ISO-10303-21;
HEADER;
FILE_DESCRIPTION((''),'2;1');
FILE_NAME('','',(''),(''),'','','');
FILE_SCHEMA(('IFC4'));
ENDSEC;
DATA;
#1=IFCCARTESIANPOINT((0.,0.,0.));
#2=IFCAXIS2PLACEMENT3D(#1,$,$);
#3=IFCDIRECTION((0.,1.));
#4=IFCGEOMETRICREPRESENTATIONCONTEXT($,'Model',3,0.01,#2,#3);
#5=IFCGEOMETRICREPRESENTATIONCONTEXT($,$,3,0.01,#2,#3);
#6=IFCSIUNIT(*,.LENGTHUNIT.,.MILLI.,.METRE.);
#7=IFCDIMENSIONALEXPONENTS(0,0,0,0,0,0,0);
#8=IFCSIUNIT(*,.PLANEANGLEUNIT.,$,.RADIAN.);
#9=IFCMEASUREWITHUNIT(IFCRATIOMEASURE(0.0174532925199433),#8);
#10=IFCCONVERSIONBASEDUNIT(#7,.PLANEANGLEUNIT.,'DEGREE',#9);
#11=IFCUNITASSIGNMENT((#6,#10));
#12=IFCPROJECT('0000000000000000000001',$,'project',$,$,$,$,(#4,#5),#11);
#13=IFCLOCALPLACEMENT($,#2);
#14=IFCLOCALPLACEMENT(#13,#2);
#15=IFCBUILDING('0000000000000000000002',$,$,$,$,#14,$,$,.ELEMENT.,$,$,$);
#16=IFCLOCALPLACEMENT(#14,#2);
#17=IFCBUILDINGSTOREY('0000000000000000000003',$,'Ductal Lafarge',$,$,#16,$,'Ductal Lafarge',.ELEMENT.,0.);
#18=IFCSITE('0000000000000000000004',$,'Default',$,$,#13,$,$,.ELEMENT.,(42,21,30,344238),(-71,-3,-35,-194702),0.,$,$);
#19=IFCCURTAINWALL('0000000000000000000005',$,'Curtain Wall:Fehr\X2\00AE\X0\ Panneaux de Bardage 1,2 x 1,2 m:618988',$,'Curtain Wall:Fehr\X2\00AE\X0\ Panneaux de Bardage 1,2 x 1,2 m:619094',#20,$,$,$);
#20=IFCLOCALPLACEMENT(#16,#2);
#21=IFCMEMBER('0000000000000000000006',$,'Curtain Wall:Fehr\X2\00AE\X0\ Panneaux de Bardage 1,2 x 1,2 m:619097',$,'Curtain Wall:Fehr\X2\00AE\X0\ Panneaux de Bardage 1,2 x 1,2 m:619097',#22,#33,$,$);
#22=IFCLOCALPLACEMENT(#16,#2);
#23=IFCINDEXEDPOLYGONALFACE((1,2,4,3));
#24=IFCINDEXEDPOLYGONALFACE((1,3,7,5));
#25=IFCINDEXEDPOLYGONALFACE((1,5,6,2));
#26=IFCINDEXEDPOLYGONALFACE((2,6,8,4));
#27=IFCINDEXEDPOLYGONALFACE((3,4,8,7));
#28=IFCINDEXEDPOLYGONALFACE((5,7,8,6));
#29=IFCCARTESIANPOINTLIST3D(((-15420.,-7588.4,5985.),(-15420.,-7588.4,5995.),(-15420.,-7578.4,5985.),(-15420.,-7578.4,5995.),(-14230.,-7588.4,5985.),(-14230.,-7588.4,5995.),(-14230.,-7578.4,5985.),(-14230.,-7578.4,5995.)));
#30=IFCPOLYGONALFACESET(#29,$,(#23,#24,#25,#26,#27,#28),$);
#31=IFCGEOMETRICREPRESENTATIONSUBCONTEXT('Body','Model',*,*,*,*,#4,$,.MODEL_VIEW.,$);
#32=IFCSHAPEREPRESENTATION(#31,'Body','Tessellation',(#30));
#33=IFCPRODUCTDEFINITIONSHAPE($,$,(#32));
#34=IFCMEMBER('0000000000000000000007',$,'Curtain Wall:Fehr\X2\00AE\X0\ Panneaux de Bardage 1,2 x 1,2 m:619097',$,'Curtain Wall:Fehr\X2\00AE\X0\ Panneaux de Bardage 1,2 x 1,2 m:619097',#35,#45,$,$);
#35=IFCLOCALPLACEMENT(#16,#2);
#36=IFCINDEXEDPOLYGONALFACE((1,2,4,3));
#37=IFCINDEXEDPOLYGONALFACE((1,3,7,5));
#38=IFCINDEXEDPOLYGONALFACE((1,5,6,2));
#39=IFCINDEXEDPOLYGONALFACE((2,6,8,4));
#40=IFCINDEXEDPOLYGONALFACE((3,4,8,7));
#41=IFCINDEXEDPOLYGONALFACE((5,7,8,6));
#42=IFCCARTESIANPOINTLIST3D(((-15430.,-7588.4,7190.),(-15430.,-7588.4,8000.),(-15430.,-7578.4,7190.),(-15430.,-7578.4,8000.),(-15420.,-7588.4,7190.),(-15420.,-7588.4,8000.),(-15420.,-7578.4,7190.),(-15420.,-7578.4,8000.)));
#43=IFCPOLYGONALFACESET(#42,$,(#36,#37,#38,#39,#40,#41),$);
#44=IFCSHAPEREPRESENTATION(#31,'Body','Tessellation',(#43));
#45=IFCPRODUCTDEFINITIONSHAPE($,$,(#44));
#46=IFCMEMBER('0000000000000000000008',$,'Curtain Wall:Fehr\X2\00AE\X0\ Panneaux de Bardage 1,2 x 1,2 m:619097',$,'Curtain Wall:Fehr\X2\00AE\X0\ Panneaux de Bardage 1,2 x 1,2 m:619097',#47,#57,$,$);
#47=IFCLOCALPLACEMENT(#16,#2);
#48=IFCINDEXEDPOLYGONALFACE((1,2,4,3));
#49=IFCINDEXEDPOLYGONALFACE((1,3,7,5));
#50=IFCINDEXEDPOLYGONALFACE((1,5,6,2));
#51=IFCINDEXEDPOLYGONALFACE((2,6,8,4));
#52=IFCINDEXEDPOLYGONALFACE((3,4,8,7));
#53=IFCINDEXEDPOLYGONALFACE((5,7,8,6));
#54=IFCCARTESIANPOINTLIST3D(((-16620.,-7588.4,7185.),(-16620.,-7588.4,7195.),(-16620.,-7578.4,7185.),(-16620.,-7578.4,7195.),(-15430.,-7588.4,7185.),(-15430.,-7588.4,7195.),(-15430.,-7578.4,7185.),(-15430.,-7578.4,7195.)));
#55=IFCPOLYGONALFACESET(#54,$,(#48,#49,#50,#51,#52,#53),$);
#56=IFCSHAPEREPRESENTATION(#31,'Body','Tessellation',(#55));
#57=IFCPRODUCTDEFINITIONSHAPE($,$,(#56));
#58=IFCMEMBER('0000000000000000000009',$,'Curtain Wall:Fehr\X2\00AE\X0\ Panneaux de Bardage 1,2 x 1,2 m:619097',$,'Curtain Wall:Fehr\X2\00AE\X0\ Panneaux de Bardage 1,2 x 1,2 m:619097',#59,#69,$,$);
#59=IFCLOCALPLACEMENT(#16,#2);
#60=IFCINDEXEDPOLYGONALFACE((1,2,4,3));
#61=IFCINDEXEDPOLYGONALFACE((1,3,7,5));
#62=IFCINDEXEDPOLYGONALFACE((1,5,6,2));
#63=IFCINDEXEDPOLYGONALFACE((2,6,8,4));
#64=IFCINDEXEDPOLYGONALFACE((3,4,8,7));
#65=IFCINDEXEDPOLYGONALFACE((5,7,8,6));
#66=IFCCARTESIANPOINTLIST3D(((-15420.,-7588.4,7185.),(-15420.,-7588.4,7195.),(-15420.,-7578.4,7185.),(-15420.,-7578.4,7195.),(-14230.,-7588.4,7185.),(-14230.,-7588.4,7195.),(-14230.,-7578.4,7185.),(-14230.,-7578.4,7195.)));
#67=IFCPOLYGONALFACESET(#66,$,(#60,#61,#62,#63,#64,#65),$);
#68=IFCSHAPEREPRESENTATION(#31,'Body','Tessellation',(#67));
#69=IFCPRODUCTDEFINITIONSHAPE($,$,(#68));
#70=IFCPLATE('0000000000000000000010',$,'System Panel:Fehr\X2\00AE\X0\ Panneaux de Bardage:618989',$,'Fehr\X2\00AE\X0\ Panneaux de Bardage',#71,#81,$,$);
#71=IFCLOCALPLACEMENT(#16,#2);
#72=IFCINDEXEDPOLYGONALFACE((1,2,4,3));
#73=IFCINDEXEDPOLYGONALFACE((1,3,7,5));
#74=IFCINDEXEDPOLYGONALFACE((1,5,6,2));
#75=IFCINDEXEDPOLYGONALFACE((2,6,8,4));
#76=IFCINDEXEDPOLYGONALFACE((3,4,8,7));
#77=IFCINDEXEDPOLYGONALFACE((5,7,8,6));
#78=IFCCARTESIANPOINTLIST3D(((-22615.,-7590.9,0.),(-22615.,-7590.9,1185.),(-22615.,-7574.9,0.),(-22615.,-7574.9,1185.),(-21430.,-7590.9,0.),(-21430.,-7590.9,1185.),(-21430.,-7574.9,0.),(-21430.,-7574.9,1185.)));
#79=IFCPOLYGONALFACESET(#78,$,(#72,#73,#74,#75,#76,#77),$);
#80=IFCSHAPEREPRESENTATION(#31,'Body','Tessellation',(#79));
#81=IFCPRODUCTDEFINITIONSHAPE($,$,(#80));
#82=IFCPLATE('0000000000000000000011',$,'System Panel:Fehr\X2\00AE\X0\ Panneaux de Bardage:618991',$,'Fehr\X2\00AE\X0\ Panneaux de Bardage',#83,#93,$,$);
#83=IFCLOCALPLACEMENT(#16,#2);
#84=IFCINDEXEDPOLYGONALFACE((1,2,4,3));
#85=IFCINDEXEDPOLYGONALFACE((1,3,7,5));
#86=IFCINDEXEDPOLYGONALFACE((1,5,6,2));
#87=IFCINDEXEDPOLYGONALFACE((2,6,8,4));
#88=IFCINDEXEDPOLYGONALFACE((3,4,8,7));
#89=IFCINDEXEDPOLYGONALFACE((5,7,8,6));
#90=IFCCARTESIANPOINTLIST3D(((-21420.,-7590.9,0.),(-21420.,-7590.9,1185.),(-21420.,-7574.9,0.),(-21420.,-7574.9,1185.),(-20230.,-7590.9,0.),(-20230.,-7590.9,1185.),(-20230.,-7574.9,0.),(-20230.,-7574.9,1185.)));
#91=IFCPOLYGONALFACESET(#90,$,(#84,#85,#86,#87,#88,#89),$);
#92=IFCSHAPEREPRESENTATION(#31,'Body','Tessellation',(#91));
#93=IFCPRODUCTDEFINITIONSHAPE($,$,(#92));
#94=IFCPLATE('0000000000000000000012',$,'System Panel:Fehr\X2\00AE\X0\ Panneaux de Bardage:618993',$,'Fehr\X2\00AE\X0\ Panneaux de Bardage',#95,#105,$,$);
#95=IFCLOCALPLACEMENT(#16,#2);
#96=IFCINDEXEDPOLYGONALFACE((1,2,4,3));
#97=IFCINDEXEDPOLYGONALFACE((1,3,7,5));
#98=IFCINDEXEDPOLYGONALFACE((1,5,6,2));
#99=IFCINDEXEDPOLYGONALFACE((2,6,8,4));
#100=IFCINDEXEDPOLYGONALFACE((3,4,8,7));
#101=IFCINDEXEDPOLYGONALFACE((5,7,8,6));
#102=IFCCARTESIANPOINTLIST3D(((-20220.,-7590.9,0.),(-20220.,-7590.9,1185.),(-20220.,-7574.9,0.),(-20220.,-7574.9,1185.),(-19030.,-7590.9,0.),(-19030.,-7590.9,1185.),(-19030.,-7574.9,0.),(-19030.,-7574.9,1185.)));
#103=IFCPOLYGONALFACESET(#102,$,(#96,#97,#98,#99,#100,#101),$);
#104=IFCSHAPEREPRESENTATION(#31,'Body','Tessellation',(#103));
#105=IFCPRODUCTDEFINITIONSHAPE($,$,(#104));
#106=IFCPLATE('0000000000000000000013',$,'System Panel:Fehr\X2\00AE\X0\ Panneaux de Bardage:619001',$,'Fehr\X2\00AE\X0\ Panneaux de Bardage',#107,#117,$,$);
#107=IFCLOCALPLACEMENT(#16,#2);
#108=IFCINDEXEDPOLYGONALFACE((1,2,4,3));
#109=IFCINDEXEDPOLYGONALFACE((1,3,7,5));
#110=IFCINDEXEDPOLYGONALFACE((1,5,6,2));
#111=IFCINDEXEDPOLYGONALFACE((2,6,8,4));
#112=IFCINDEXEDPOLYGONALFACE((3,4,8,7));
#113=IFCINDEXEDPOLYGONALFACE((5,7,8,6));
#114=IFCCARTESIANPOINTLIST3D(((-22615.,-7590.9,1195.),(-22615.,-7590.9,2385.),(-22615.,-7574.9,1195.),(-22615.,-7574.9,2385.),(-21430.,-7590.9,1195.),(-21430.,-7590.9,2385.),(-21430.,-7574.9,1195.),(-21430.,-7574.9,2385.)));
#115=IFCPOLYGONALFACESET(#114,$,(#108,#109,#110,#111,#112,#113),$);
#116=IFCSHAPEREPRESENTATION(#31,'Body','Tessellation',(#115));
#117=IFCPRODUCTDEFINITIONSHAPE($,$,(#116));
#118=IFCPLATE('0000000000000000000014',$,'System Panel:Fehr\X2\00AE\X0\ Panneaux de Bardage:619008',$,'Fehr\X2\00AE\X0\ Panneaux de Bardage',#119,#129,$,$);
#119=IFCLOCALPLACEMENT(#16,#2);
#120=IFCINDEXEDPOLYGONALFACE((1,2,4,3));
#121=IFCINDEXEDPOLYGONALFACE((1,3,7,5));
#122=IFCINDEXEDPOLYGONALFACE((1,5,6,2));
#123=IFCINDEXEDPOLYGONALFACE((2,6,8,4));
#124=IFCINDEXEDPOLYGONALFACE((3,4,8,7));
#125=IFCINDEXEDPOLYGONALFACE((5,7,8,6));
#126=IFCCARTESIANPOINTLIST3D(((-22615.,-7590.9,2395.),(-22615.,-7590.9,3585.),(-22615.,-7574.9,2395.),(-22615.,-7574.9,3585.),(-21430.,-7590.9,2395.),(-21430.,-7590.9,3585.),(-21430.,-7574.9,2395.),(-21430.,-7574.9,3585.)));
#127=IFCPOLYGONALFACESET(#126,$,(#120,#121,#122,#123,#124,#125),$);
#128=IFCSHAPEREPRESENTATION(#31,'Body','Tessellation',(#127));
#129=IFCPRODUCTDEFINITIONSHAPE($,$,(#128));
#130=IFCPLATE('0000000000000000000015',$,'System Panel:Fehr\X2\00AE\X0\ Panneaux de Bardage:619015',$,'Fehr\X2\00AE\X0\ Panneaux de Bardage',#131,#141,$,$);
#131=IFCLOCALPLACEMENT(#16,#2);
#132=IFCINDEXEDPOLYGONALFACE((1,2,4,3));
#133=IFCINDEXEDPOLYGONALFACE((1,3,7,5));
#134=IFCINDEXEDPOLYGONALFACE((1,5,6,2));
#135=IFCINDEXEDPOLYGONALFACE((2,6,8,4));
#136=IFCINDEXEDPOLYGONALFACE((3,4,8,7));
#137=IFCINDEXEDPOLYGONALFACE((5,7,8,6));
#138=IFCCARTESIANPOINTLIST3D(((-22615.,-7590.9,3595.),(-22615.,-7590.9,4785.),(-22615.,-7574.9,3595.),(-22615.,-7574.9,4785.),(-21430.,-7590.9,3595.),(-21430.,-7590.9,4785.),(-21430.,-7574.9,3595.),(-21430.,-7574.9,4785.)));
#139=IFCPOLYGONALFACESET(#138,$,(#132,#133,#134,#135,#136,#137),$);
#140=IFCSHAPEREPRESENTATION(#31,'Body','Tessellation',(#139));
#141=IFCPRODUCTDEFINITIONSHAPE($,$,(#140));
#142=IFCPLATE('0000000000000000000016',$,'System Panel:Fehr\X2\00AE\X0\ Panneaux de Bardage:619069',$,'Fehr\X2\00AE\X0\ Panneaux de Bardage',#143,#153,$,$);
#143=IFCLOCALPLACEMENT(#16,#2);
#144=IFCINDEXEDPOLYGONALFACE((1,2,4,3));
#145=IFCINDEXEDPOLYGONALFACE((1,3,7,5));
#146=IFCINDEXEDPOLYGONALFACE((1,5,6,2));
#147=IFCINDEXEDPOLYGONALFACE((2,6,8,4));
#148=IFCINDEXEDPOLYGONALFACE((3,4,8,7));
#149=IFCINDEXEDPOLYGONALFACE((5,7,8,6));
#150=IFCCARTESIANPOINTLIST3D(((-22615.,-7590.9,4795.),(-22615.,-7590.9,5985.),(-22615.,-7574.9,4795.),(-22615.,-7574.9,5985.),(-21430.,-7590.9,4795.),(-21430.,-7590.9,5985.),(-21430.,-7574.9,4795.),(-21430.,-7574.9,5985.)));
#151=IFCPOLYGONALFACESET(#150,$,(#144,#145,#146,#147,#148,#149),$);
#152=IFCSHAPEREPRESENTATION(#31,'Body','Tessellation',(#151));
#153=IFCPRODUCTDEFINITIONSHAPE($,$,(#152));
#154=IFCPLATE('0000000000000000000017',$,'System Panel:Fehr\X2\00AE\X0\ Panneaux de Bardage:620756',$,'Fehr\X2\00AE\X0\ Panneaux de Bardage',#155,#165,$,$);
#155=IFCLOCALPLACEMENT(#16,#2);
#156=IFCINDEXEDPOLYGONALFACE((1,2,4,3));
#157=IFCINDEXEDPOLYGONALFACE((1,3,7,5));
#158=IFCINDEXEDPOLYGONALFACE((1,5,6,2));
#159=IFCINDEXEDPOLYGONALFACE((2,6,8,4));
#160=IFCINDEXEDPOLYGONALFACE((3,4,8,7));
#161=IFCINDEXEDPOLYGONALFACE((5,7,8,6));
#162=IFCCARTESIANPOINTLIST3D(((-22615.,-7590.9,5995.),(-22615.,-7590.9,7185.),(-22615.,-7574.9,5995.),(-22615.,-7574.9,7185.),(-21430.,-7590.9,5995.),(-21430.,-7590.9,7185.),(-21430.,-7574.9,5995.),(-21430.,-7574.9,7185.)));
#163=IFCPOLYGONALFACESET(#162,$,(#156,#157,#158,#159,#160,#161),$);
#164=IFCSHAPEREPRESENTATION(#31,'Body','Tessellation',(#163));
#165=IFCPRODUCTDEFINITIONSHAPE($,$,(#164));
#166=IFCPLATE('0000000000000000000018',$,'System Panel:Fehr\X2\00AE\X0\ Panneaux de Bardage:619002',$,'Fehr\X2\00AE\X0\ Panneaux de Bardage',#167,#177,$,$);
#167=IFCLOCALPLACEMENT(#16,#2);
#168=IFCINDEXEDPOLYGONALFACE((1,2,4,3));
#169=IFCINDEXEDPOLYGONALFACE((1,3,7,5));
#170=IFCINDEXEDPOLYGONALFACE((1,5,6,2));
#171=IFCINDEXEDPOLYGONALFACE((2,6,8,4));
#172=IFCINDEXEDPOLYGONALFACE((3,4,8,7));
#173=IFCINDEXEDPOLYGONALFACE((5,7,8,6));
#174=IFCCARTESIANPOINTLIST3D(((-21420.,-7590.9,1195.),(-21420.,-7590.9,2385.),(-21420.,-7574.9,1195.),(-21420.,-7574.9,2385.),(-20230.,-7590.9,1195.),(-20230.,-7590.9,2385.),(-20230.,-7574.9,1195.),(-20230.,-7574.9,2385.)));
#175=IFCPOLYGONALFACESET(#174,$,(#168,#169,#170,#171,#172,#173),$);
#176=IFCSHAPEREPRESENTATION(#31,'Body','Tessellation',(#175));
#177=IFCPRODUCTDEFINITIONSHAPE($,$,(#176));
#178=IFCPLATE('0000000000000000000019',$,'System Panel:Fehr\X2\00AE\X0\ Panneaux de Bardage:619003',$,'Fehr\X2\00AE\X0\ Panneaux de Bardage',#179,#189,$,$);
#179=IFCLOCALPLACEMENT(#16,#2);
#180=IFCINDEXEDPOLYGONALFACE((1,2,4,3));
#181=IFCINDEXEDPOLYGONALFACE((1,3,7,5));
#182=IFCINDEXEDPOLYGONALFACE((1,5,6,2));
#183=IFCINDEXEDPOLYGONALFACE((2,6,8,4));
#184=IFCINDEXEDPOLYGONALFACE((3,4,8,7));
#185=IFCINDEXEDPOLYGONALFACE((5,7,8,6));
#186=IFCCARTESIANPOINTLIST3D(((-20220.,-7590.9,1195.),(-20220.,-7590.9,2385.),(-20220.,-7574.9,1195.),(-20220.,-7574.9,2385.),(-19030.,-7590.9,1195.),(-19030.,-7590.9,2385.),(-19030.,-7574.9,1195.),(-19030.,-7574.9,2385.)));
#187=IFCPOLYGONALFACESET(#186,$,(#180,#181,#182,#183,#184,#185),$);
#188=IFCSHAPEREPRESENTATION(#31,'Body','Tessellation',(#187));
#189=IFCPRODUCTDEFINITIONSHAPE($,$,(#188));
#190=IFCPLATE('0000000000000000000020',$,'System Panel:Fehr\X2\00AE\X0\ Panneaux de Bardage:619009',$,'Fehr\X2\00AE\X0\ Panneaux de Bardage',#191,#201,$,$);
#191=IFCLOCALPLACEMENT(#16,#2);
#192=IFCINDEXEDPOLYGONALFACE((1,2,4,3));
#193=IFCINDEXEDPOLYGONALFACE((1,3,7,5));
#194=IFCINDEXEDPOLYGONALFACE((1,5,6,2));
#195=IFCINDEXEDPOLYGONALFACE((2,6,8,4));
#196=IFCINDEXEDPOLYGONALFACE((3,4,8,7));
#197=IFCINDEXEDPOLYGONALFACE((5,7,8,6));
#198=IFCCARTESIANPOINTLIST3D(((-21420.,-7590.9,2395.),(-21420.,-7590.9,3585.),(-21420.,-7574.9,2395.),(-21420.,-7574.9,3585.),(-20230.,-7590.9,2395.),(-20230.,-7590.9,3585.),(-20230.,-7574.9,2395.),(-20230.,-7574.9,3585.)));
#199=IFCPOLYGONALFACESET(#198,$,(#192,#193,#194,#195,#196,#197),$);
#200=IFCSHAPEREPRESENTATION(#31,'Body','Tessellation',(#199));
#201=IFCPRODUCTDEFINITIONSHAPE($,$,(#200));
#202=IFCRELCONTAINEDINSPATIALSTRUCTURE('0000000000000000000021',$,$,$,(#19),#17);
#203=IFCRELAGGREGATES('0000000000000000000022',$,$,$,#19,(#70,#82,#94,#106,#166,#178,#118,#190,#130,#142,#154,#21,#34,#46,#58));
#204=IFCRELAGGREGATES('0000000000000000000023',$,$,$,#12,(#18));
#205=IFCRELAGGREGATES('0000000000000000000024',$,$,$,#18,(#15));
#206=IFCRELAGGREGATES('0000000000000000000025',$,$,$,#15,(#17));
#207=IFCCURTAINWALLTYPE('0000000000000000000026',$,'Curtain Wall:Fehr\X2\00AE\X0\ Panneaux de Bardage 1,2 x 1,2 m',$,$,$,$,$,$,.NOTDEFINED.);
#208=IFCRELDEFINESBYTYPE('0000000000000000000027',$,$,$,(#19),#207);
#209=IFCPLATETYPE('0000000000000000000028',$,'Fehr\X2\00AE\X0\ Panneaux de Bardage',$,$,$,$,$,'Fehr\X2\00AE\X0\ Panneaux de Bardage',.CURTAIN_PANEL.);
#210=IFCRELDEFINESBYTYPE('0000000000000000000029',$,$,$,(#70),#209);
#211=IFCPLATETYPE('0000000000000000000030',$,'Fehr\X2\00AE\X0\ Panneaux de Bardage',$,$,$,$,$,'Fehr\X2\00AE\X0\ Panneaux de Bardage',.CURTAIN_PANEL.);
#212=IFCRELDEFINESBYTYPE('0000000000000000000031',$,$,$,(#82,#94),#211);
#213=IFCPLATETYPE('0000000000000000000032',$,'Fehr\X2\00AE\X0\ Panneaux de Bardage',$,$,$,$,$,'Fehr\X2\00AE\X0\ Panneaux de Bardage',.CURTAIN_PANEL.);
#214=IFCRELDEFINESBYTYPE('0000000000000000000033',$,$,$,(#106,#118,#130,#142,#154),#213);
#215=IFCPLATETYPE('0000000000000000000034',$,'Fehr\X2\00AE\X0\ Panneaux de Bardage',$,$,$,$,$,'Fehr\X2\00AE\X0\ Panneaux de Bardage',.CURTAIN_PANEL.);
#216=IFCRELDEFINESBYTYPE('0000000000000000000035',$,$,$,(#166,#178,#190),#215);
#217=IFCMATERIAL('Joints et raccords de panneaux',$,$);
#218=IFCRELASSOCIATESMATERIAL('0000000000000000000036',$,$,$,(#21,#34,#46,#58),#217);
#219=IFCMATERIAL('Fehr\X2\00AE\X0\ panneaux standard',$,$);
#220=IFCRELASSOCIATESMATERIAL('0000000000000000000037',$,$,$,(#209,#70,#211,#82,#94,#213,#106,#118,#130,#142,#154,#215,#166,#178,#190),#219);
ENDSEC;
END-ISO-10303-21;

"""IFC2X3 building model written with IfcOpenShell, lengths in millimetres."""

from ifc_helpers import new_model, entity, si_unit, converted_unit, direction, frame, frame_2d, origin, origin_2d_with_axis, place, context, subcontext, project, spatial, rectangle, extrude, source, transform, mapped, material, type_object, type_shapes, element, aggregate, save


model = new_model("IFC2X3")

# Units and contexts
model_context = context("Model", 3, precision=0.01, world=origin(), true_north=direction((0.0, 1.0)))
context_of_model = context(None, 3, precision=0.01, world=origin(), true_north=direction((0.0, 1.0)))
body_context = subcontext(model_context, "Body", "Model", "MODEL_VIEW")
ifc_project = project(units=[si_unit("LENGTHUNIT", "METRE", prefix="MILLI"), converted_unit("PLANEANGLEUNIT", "DEGREE", entity("IfcRatioMeasure", 0.0174532925199433), si_unit("PLANEANGLEUNIT", "RADIAN"), dimensions=[0, 0, 0, 0, 0, 0, 0])], contexts=[model_context, context_of_model])

# Site, building, storey
site_placement = place(None, origin())
site = spatial("IfcSite", under=ifc_project, at=site_placement, Name="Default", CompositionType="ELEMENT", RefLatitude=(42, 21, 30, 344238), RefLongitude=(-71, -3, -35, -194702), RefElevation=0.0)
building_placement = place(site_placement, origin())
building = spatial("IfcBuilding", under=site, at=building_placement, CompositionType="ELEMENT")
storey_placement = place(building_placement, origin())
storey = spatial("IfcBuildingStorey", under=building, at=storey_placement, Name="Ductal Lafarge", LongName="Ductal Lafarge", CompositionType="ELEMENT", Elevation=0.0)

# Curtain wall, members, plates
curtain_wall_type = type_object("IfcCurtainWallType", Name="Curtain Wall:Fehr® Panneaux de Bardage 1,2 x 1,2 m", PredefinedType="NOTDEFINED")
curtain_wall_placement = place(storey_placement, origin())
curtain_wall = element("IfcCurtainWall", 1, at=curtain_wall_placement, inside=storey, type_object=curtain_wall_type, Name="Curtain Wall:Fehr® Panneaux de Bardage 1,2 x 1,2 m:618988", ObjectType="Curtain Wall:Fehr® Panneaux de Bardage 1,2 x 1,2 m:619094")
ifc_material_1 = material(Name="Joints et raccords de panneaux")
member_1_placement = place(curtain_wall_placement, frame((-15420.0, -7588.4, 5985.0)))
member_1 = element("IfcMember", 2, at=member_1_placement, material=ifc_material_1, Name="Curtain Wall:Fehr® Panneaux de Bardage 1,2 x 1,2 m:619097", ObjectType="Curtain Wall:Fehr® Panneaux de Bardage 1,2 x 1,2 m:619097", context=body_context, shape_type="SweptSolid", body=[
    extrude(rectangle(XDim=1190.0, YDim=10.0, at=frame_2d((0.0, 0.0), x_axis=(1.0, 0.0))), frame((595.0, 5.0, 0.0), z_axis=(0.0, 0.0, 1.0), x_axis=(-1.0, 0.0, 0.0)), (0.0, 0.0, 1.0), 10.0),
])
member_2_placement = place(curtain_wall_placement, frame((-15430.0, -7588.4, 7190.0)))
member_2 = element("IfcMember", 3, at=member_2_placement, material=ifc_material_1, Name="Curtain Wall:Fehr® Panneaux de Bardage 1,2 x 1,2 m:619097", ObjectType="Curtain Wall:Fehr® Panneaux de Bardage 1,2 x 1,2 m:619097", context=body_context, shape_type="SweptSolid", body=[
    extrude(rectangle(XDim=10.0, YDim=10.0, at=frame_2d((0.0, 0.0), x_axis=(1.0, 0.0))), frame((5.0, 5.0, 0.0), z_axis=(0.0, 0.0, 1.0), x_axis=(0.0, 1.0, 0.0)), (0.0, 0.0, 1.0), 810.0),
])
member_3_placement = place(curtain_wall_placement, frame((-16620.0, -7588.4, 7185.0)))
member_3 = element("IfcMember", 4, at=member_3_placement, material=ifc_material_1, Name="Curtain Wall:Fehr® Panneaux de Bardage 1,2 x 1,2 m:619097", ObjectType="Curtain Wall:Fehr® Panneaux de Bardage 1,2 x 1,2 m:619097", context=body_context, shape_type="SweptSolid", body=[
    extrude(rectangle(XDim=1190.0, YDim=10.0, at=frame_2d((0.0, 0.0), x_axis=(1.0, 0.0))), frame((595.0, 5.0, 0.0), z_axis=(0.0, 0.0, 1.0), x_axis=(-1.0, 0.0, 0.0)), (0.0, 0.0, 1.0), 10.0),
])
member_4_placement = place(curtain_wall_placement, frame((-15420.0, -7588.4, 7185.0)))
member_4 = element("IfcMember", 5, at=member_4_placement, material=ifc_material_1, Name="Curtain Wall:Fehr® Panneaux de Bardage 1,2 x 1,2 m:619097", ObjectType="Curtain Wall:Fehr® Panneaux de Bardage 1,2 x 1,2 m:619097", context=body_context, shape_type="SweptSolid", body=[
    extrude(rectangle(XDim=1190.0, YDim=10.0, at=frame_2d((0.0, 0.0), x_axis=(1.0, 0.0))), frame((595.0, 5.0, 0.0), z_axis=(0.0, 0.0, 1.0), x_axis=(-1.0, 0.0, 0.0)), (0.0, 0.0, 1.0), 10.0),
])
ifc_material_2 = material(Name="Fehr® panneaux standard")
plate_type_1 = type_object("IfcPlateType", Name="Fehr® Panneaux de Bardage", ElementType="Fehr® Panneaux de Bardage", PredefinedType="CURTAIN_PANEL", material=ifc_material_2)
shared_shape_1 = source(origin(), body_context, "Body", "SweptSolid", [
    extrude(rectangle(XDim=16.0, YDim=1185.0, at=origin_2d_with_axis()), frame((0.0, 0.0, 0.0), z_axis=(0.0, 0.0, 1.0), x_axis=(0.0, 1.0, 0.0)), (0.0, 0.0, 1.0), 1185.0),
])
type_shapes(plate_type_1, [shared_shape_1])
plate_1_placement = place(curtain_wall_placement, frame((-22022.5, -7582.9, 0.0)))
plate_1 = element("IfcPlate", 6, at=plate_1_placement, type_object=plate_type_1, material=ifc_material_2, Name="System Panel:Fehr® Panneaux de Bardage:618989", ObjectType="Fehr® Panneaux de Bardage", context=body_context, shape_type="MappedRepresentation", body=[
    mapped(shared_shape_1, transform((0.0, 0.0, 0.0), scale=1.0)),
])
plate_type_2 = type_object("IfcPlateType", Name="Fehr® Panneaux de Bardage", ElementType="Fehr® Panneaux de Bardage", PredefinedType="CURTAIN_PANEL", material=ifc_material_2)
shared_shape_2 = source(origin(), body_context, "Body", "SweptSolid", [
    extrude(rectangle(XDim=16.0, YDim=1190.0, at=origin_2d_with_axis()), frame((0.0, 0.0, 0.0), z_axis=(0.0, 0.0, 1.0), x_axis=(0.0, 1.0, 0.0)), (0.0, 0.0, 1.0), 1185.0),
])
type_shapes(plate_type_2, [shared_shape_2])
plate_2_placement = place(curtain_wall_placement, frame((-20825.0, -7582.9, 0.0)))
plate_2 = element("IfcPlate", 7, at=plate_2_placement, type_object=plate_type_2, material=ifc_material_2, Name="System Panel:Fehr® Panneaux de Bardage:618991", ObjectType="Fehr® Panneaux de Bardage", context=body_context, shape_type="MappedRepresentation", body=[
    mapped(shared_shape_2, transform((0.0, 0.0, 0.0), scale=1.0)),
])
plate_3_placement = place(curtain_wall_placement, frame((-19625.0, -7582.9, 0.0)))
plate_3 = element("IfcPlate", 8, at=plate_3_placement, type_object=plate_type_2, material=ifc_material_2, Name="System Panel:Fehr® Panneaux de Bardage:618993", ObjectType="Fehr® Panneaux de Bardage", context=body_context, shape_type="MappedRepresentation", body=[
    mapped(shared_shape_2, transform((0.0, 0.0, 0.0), scale=1.0)),
])
plate_type_3 = type_object("IfcPlateType", Name="Fehr® Panneaux de Bardage", ElementType="Fehr® Panneaux de Bardage", PredefinedType="CURTAIN_PANEL", material=ifc_material_2)
shared_shape_3 = source(origin(), body_context, "Body", "SweptSolid", [
    extrude(rectangle(XDim=16.0, YDim=1185.0, at=origin_2d_with_axis()), frame((0.0, 0.0, 0.0), z_axis=(0.0, 0.0, 1.0), x_axis=(0.0, 1.0, 0.0)), (0.0, 0.0, 1.0), 1190.0),
])
type_shapes(plate_type_3, [shared_shape_3])
plate_4_placement = place(curtain_wall_placement, frame((-22022.5, -7582.9, 1195.0)))
plate_4 = element("IfcPlate", 9, at=plate_4_placement, type_object=plate_type_3, material=ifc_material_2, Name="System Panel:Fehr® Panneaux de Bardage:619001", ObjectType="Fehr® Panneaux de Bardage", context=body_context, shape_type="MappedRepresentation", body=[
    mapped(shared_shape_3, transform((0.0, 0.0, 0.0), scale=1.0)),
])
plate_5_placement = place(curtain_wall_placement, frame((-22022.5, -7582.9, 2395.0)))
plate_5 = element("IfcPlate", 10, at=plate_5_placement, type_object=plate_type_3, material=ifc_material_2, Name="System Panel:Fehr® Panneaux de Bardage:619008", ObjectType="Fehr® Panneaux de Bardage", context=body_context, shape_type="MappedRepresentation", body=[
    mapped(shared_shape_3, transform((0.0, 0.0, 0.0), scale=1.0)),
])
plate_6_placement = place(curtain_wall_placement, frame((-22022.5, -7582.9, 3595.0)))
plate_6 = element("IfcPlate", 11, at=plate_6_placement, type_object=plate_type_3, material=ifc_material_2, Name="System Panel:Fehr® Panneaux de Bardage:619015", ObjectType="Fehr® Panneaux de Bardage", context=body_context, shape_type="MappedRepresentation", body=[
    mapped(shared_shape_3, transform((0.0, 0.0, 0.0), scale=1.0)),
])
plate_7_placement = place(curtain_wall_placement, frame((-22022.5, -7582.9, 4795.0)))
plate_7 = element("IfcPlate", 12, at=plate_7_placement, type_object=plate_type_3, material=ifc_material_2, Name="System Panel:Fehr® Panneaux de Bardage:619069", ObjectType="Fehr® Panneaux de Bardage", context=body_context, shape_type="MappedRepresentation", body=[
    mapped(shared_shape_3, transform((0.0, 0.0, 0.0), scale=1.0)),
])
plate_8_placement = place(curtain_wall_placement, frame((-22022.5, -7582.9, 5995.0)))
plate_8 = element("IfcPlate", 13, at=plate_8_placement, type_object=plate_type_3, material=ifc_material_2, Name="System Panel:Fehr® Panneaux de Bardage:620756", ObjectType="Fehr® Panneaux de Bardage", context=body_context, shape_type="MappedRepresentation", body=[
    mapped(shared_shape_3, transform((0.0, 0.0, 0.0), scale=1.0)),
])
plate_type_4 = type_object("IfcPlateType", Name="Fehr® Panneaux de Bardage", ElementType="Fehr® Panneaux de Bardage", PredefinedType="CURTAIN_PANEL", material=ifc_material_2)
shared_shape_4 = source(origin(), body_context, "Body", "SweptSolid", [
    extrude(rectangle(XDim=16.0, YDim=1190.0, at=origin_2d_with_axis()), frame((0.0, 0.0, 0.0), z_axis=(0.0, 0.0, 1.0), x_axis=(0.0, 1.0, 0.0)), (0.0, 0.0, 1.0), 1190.0),
])
type_shapes(plate_type_4, [shared_shape_4])
plate_9_placement = place(curtain_wall_placement, frame((-20825.0, -7582.9, 1195.0)))
plate_9 = element("IfcPlate", 14, at=plate_9_placement, type_object=plate_type_4, material=ifc_material_2, Name="System Panel:Fehr® Panneaux de Bardage:619002", ObjectType="Fehr® Panneaux de Bardage", context=body_context, shape_type="MappedRepresentation", body=[
    mapped(shared_shape_4, transform((0.0, 0.0, 0.0), scale=1.0)),
])
plate_10_placement = place(curtain_wall_placement, frame((-19625.0, -7582.9, 1195.0)))
plate_10 = element("IfcPlate", 15, at=plate_10_placement, type_object=plate_type_4, material=ifc_material_2, Name="System Panel:Fehr® Panneaux de Bardage:619003", ObjectType="Fehr® Panneaux de Bardage", context=body_context, shape_type="MappedRepresentation", body=[
    mapped(shared_shape_4, transform((0.0, 0.0, 0.0), scale=1.0)),
])
plate_11_placement = place(curtain_wall_placement, frame((-20825.0, -7582.9, 2395.0)))
plate_11 = element("IfcPlate", 16, at=plate_11_placement, type_object=plate_type_4, material=ifc_material_2, Name="System Panel:Fehr® Panneaux de Bardage:619009", ObjectType="Fehr® Panneaux de Bardage", context=body_context, shape_type="MappedRepresentation", body=[
    mapped(shared_shape_4, transform((0.0, 0.0, 0.0), scale=1.0)),
])
aggregate(curtain_wall, [plate_1, plate_2, plate_3, plate_4, plate_9, plate_10, plate_5, plate_11, plate_6, plate_7, plate_8, member_1, member_2, member_3, member_4])

save(model, "model.ifc")
